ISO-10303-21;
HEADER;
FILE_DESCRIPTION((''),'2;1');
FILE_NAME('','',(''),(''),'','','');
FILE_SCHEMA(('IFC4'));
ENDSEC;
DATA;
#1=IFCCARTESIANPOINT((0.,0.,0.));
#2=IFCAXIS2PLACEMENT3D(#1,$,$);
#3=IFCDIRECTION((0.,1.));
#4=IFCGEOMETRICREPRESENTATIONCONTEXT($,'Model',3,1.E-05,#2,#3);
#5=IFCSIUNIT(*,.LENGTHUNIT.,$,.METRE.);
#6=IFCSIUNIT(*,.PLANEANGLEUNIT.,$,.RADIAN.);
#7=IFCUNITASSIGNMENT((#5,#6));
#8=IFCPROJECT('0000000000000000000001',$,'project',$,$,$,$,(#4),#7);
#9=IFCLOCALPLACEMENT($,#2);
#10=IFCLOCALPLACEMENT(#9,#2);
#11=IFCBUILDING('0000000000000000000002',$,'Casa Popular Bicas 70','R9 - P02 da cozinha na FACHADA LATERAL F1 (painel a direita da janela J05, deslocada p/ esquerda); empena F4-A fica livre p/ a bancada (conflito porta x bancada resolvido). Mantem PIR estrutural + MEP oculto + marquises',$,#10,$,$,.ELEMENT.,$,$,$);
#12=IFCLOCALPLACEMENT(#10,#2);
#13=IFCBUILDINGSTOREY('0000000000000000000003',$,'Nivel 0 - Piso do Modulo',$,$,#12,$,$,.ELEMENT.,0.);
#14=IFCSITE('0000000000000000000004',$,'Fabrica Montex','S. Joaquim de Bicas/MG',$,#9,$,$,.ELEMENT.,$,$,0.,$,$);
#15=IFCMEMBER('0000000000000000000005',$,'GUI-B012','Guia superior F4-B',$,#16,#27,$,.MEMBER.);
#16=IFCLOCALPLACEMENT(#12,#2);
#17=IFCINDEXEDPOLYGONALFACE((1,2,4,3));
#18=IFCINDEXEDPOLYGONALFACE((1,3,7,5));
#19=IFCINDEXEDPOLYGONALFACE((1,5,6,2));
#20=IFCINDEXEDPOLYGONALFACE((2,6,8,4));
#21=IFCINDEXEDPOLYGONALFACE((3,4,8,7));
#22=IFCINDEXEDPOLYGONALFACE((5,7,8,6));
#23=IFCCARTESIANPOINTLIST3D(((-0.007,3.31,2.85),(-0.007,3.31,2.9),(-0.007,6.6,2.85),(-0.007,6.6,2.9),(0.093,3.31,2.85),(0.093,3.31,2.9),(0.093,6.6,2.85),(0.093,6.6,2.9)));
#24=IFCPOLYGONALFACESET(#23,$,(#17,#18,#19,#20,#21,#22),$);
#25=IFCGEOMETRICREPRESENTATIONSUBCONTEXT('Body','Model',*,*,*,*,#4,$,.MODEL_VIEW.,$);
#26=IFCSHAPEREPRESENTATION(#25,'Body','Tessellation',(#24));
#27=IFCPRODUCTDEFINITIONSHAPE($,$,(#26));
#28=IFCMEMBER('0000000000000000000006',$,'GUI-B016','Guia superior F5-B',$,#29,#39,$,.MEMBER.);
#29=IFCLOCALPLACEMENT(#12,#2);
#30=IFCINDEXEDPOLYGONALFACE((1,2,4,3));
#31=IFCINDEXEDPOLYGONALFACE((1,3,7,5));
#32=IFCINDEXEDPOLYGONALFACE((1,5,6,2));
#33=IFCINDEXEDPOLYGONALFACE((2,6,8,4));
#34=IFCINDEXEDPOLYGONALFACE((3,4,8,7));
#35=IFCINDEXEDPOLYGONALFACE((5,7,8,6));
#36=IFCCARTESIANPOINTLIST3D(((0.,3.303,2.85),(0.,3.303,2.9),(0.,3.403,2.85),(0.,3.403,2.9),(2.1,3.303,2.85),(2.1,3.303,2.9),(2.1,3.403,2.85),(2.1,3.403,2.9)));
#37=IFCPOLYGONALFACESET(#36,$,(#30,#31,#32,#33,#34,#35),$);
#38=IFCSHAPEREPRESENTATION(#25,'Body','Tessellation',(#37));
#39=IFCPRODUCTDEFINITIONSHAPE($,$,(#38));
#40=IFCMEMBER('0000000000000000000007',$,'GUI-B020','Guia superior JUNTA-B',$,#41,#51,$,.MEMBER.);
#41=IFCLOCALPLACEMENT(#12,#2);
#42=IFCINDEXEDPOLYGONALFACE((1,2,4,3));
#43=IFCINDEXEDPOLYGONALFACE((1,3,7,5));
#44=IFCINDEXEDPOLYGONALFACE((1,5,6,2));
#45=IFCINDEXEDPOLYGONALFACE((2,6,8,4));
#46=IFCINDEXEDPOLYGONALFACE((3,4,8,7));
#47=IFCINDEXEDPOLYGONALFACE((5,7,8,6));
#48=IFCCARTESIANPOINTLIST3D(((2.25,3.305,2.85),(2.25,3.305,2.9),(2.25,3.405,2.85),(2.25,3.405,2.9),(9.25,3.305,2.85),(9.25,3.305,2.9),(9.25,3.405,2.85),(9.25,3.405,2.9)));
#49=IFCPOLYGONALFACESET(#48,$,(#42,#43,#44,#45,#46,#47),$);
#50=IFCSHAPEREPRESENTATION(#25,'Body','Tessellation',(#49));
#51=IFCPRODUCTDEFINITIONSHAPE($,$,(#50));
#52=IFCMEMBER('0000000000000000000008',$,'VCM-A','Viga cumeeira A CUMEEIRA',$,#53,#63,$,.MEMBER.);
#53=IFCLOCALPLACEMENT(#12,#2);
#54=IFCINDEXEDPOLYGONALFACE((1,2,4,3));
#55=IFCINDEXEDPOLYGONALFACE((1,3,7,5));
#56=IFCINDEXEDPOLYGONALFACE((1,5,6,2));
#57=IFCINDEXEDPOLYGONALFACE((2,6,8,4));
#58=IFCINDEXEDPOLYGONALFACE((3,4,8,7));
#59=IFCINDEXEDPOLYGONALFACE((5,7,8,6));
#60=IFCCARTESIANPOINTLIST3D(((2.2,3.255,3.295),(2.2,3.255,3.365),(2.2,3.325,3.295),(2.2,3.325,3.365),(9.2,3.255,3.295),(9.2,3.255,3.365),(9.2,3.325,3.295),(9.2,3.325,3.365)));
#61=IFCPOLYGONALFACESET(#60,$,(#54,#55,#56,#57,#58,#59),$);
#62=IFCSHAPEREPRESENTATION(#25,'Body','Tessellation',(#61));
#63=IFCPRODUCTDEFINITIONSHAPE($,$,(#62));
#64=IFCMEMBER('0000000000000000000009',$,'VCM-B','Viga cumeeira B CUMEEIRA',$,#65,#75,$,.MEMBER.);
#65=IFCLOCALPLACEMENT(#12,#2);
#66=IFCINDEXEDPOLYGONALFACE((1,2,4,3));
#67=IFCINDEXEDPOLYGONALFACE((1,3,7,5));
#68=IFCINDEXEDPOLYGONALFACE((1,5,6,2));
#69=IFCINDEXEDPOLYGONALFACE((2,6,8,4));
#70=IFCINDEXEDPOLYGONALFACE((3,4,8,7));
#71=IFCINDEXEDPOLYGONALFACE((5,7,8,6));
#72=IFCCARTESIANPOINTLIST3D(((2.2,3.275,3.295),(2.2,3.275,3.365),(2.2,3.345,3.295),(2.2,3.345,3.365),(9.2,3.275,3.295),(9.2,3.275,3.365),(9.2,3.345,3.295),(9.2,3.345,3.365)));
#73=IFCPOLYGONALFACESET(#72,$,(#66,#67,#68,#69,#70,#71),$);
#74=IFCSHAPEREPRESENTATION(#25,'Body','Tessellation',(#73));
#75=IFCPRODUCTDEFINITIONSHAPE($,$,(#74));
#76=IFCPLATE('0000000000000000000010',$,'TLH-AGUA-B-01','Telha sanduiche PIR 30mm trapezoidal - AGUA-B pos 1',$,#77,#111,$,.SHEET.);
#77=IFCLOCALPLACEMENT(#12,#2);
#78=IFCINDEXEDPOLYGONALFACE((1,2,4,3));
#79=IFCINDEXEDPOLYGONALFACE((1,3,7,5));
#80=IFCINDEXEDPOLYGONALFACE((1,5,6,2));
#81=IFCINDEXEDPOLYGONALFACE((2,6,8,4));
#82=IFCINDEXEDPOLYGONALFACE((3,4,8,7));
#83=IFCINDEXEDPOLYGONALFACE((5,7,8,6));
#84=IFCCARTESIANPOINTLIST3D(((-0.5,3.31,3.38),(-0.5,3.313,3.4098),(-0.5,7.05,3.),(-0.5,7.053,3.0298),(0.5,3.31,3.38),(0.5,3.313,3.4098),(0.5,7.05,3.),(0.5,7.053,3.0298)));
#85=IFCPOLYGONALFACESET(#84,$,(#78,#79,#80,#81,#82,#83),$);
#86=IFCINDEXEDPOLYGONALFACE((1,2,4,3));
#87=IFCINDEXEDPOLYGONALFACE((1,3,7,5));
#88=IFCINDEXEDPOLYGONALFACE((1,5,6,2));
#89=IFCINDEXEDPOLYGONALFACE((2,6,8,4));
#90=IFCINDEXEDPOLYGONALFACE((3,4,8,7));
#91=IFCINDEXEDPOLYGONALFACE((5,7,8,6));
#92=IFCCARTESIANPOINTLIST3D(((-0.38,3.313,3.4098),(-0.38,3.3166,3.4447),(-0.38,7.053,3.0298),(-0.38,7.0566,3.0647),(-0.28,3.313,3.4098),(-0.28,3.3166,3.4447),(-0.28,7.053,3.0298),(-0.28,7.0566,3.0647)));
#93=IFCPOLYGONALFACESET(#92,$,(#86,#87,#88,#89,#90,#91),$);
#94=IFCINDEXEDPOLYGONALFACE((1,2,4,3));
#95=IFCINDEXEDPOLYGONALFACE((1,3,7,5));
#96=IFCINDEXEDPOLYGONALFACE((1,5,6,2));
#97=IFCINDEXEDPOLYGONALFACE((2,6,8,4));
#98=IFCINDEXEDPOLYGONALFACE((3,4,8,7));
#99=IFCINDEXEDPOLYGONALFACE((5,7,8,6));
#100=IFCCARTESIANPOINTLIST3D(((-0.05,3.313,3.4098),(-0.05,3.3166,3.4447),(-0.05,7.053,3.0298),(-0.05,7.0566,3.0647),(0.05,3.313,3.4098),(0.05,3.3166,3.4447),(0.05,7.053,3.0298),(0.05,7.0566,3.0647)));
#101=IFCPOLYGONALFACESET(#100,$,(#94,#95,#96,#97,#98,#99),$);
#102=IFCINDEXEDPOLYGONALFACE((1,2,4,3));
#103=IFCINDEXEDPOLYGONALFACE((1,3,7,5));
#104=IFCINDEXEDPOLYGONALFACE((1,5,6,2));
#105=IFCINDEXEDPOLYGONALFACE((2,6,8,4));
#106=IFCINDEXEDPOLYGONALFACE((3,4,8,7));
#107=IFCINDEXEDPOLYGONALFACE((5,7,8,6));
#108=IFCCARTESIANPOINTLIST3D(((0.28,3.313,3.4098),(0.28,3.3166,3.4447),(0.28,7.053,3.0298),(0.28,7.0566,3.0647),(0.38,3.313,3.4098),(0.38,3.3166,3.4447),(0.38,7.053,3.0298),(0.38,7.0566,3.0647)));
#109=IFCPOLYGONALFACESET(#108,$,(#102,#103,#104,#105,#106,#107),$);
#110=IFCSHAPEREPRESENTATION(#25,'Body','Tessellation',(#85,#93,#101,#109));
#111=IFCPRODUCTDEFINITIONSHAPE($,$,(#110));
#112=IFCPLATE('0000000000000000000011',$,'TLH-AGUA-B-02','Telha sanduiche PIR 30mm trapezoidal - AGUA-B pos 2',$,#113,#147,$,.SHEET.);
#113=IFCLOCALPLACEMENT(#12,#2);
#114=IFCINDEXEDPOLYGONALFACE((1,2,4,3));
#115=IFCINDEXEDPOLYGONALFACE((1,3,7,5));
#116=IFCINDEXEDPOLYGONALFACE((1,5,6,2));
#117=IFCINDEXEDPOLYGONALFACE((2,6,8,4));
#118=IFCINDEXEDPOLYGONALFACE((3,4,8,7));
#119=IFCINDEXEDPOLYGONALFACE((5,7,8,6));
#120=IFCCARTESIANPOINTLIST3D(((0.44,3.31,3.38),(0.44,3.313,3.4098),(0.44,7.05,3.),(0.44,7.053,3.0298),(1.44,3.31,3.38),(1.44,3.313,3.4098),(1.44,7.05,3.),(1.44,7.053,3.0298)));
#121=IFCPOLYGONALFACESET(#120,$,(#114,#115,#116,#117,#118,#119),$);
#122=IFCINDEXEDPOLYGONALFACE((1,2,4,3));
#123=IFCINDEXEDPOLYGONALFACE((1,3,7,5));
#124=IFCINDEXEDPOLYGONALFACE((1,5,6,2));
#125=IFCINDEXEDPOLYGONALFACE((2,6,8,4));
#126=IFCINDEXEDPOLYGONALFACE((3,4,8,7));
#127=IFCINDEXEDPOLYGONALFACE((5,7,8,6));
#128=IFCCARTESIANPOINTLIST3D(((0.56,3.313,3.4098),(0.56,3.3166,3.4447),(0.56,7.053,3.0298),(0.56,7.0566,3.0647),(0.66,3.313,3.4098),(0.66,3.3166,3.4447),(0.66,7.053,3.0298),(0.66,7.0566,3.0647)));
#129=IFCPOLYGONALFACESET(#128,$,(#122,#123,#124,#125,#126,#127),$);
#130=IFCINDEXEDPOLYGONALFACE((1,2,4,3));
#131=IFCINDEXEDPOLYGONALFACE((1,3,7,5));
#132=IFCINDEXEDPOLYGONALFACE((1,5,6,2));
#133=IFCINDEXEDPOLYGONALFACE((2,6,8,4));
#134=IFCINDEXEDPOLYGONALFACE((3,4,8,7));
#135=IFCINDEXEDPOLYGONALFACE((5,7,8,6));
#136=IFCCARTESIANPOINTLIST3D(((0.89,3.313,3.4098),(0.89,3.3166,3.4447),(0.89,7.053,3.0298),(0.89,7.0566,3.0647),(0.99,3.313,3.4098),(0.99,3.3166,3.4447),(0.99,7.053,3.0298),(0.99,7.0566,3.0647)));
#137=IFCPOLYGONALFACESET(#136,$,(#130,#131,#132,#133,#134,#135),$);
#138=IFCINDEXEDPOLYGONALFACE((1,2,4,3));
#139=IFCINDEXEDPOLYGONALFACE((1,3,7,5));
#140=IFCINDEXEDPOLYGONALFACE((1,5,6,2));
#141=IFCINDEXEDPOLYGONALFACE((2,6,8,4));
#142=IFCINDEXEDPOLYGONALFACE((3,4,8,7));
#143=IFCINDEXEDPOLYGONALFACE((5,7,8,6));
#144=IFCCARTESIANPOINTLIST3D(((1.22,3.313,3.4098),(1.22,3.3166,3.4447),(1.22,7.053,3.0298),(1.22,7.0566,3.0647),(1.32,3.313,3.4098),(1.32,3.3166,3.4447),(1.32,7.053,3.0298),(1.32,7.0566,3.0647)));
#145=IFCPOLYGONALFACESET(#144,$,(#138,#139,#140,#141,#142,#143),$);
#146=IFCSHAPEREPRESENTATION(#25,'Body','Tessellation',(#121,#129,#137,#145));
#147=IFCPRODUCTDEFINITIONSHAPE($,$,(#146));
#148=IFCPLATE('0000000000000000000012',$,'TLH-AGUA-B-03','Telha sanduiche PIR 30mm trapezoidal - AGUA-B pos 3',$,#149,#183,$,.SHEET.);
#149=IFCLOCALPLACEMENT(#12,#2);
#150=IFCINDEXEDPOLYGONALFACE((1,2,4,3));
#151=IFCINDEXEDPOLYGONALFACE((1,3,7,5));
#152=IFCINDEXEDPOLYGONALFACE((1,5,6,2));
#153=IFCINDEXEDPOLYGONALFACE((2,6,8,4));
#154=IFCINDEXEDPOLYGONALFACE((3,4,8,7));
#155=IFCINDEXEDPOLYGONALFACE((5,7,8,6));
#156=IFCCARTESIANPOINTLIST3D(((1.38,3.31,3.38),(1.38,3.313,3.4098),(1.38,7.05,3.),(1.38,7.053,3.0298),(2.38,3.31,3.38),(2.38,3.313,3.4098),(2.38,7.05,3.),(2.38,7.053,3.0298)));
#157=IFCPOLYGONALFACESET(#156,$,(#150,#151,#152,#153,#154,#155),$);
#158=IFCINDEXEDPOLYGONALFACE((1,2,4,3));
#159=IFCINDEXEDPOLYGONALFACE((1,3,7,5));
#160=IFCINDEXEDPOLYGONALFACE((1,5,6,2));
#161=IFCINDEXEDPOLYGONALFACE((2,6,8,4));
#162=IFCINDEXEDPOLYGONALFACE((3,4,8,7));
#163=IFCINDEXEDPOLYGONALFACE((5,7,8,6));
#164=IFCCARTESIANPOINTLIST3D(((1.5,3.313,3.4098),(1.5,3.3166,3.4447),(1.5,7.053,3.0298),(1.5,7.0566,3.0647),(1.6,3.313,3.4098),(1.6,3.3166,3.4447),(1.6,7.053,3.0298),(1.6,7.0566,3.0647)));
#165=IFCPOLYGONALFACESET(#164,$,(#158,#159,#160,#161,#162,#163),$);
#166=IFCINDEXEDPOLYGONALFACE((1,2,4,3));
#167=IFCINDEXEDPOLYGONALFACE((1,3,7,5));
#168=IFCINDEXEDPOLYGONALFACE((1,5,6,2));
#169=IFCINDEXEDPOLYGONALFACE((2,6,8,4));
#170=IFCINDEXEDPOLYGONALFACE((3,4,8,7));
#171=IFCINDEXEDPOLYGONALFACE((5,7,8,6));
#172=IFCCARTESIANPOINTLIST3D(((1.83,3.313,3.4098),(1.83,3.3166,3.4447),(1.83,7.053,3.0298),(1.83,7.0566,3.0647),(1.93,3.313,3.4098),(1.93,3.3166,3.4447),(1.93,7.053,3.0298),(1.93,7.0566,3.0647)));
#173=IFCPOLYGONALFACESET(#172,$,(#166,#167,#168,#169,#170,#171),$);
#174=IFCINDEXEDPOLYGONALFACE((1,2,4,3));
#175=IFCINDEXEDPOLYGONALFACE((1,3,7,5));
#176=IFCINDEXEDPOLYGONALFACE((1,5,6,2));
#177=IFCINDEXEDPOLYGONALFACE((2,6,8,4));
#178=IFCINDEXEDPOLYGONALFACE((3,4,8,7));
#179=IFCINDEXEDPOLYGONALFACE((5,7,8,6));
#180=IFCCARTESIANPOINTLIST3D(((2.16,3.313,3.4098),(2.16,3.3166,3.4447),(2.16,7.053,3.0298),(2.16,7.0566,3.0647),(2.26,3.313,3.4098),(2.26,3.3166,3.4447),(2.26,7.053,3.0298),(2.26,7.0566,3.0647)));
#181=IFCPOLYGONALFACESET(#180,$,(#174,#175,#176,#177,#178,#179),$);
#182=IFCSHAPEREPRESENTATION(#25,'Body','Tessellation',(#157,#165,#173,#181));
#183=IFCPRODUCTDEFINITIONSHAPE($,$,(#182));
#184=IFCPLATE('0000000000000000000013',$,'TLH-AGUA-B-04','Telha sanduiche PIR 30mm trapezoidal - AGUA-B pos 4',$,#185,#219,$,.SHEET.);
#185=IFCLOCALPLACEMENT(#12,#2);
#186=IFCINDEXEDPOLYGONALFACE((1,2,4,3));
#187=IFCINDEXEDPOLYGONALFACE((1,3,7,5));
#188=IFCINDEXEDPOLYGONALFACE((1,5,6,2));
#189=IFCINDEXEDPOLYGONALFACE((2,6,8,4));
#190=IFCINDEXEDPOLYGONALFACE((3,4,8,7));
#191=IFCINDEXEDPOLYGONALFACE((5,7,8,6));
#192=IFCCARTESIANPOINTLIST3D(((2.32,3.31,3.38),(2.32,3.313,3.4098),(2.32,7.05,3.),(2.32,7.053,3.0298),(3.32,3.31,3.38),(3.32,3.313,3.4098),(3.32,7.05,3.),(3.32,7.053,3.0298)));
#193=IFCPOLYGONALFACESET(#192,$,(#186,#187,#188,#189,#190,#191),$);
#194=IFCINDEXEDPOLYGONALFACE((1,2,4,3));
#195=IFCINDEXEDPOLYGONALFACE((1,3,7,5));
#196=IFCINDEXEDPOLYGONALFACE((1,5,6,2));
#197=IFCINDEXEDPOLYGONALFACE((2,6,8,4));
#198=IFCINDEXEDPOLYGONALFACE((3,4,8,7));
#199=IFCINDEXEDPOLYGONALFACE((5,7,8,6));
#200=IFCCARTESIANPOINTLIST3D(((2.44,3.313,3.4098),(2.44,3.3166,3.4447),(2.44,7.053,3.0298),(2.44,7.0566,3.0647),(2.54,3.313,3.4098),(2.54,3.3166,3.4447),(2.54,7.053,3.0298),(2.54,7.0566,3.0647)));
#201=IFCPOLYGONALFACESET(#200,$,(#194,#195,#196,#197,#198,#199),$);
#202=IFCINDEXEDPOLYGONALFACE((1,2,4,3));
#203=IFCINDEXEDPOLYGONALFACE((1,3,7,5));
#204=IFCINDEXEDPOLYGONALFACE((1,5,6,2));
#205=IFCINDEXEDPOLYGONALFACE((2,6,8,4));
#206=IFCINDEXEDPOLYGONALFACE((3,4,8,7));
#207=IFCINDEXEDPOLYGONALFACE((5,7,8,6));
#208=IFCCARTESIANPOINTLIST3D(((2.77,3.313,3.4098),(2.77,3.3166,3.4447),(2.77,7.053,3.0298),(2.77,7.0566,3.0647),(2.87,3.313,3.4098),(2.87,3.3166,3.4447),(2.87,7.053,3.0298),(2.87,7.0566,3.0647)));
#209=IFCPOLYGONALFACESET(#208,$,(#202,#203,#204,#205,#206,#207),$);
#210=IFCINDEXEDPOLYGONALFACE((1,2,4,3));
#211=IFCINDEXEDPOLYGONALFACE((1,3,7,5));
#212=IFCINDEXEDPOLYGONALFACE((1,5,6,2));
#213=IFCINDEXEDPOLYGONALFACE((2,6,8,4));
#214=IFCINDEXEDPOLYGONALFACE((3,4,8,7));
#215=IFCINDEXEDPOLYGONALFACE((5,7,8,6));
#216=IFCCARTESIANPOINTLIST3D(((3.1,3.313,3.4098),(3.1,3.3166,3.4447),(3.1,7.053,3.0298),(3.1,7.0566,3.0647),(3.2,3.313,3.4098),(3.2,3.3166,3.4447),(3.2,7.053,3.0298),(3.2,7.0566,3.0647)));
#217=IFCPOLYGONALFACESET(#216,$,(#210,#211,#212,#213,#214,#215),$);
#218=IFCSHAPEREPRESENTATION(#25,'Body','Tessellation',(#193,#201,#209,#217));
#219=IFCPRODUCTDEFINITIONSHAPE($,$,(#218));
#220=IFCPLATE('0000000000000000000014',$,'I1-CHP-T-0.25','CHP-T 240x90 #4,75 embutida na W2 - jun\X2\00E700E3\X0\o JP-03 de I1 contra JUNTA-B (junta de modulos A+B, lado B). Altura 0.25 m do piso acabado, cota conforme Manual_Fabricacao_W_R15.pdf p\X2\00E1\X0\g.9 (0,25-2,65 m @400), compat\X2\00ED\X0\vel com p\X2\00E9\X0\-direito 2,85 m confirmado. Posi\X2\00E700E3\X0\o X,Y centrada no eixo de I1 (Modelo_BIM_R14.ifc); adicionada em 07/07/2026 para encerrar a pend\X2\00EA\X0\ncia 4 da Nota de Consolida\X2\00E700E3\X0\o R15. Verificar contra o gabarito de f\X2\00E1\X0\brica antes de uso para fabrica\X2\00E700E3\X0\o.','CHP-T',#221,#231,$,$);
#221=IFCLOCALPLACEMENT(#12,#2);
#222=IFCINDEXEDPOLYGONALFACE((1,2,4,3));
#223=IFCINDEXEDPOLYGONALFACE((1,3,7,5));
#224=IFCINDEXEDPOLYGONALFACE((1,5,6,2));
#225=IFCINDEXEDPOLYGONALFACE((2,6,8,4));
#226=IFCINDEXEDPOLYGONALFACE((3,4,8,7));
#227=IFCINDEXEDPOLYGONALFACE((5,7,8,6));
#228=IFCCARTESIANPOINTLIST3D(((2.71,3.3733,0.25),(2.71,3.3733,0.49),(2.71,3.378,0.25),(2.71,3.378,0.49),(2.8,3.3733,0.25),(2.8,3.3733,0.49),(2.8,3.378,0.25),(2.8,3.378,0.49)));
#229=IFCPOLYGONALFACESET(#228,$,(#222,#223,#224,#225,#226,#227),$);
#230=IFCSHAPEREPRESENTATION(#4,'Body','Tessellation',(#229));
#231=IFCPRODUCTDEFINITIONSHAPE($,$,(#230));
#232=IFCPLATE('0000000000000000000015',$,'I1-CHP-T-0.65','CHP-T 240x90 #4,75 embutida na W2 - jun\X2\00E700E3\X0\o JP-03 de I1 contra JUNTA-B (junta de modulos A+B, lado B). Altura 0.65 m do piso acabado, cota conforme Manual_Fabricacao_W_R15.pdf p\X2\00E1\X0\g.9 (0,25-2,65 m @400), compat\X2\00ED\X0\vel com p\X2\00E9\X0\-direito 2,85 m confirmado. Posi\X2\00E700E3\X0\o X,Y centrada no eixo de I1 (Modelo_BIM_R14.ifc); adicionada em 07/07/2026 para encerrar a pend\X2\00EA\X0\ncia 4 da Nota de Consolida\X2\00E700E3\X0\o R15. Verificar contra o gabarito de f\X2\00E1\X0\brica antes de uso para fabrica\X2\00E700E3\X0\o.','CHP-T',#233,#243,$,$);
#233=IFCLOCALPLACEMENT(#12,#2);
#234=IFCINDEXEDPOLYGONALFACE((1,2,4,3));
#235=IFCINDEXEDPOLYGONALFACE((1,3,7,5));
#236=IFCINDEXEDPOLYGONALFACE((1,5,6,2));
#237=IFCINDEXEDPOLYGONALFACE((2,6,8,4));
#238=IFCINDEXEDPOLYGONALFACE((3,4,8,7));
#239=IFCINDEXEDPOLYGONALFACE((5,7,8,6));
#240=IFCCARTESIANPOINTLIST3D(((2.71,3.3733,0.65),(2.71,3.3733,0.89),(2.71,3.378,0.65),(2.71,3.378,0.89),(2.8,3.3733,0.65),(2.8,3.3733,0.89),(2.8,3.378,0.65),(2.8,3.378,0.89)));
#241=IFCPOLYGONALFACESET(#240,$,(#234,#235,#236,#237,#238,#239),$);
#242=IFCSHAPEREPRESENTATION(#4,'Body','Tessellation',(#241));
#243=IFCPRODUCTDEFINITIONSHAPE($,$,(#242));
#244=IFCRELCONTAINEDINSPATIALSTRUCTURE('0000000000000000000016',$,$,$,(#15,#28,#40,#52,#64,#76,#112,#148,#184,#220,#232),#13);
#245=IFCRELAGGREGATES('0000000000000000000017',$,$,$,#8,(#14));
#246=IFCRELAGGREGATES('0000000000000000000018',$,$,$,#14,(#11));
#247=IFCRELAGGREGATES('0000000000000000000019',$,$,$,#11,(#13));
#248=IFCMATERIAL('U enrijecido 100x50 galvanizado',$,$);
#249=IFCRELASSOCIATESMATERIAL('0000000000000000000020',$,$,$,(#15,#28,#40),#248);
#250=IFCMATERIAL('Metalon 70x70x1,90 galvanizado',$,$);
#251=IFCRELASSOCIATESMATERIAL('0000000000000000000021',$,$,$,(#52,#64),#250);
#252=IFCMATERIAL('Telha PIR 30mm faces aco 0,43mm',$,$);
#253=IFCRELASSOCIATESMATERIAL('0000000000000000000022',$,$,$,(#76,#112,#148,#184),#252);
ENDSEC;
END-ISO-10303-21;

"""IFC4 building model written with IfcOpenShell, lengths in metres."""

from ifc_helpers import new_model, si_unit, direction, frame, frame_2d, origin, origin_with_axes, origin_2d, place, context, subcontext, project, spatial, rectangle, extrude, material, element, save


model = new_model("IFC4")

# Units and contexts
model_context = context("Model", 3, precision=1e-05, world=origin(), true_north=direction((0.0, 1.0)))
body_context = subcontext(model_context, "Body", "Model", "MODEL_VIEW")
ifc_project = project(units=[si_unit("LENGTHUNIT", "METRE"), si_unit("PLANEANGLEUNIT", "RADIAN")], contexts=[model_context])

# Site, building, storey
site_placement = place(None, origin())
site = spatial("IfcSite", under=ifc_project, at=site_placement, Name="Fabrica Montex", Description="S. Joaquim de Bicas/MG", CompositionType="ELEMENT", RefElevation=0.0)
building_placement = place(site_placement, origin())
building = spatial("IfcBuilding", under=site, at=building_placement, Name="Casa Popular Bicas 70", Description="R9 - P02 da cozinha na FACHADA LATERAL F1 (painel a direita da janela J05, deslocada p/ esquerda); empena F4-A fica livre p/ a bancada (conflito porta x bancada resolvido). Mantem PIR estrutural + MEP oculto + marquises", CompositionType="ELEMENT")
storey_placement = place(building_placement, origin())
storey = spatial("IfcBuildingStorey", under=building, at=storey_placement, Name="Nivel 0 - Piso do Modulo", CompositionType="ELEMENT", Elevation=0.0)

# Members
ifc_material_1 = material(Name="U enrijecido 100x50 galvanizado")
member_1_placement = place(storey_placement, frame((0.043, 3.31, 2.875), z_axis=(0.0, 1.0, 0.0), x_axis=(0.0, 0.0, 1.0)))
element("IfcMember", 1, at=member_1_placement, inside=storey, material=ifc_material_1, Name="GUI-B012", Description="Guia superior F4-B", PredefinedType="MEMBER", context=body_context, shape_type="SweptSolid", body=[
    extrude(rectangle(XDim=0.05, YDim=0.1, at=origin_2d()), origin(), (0.0, 0.0, 1.0), 3.29),
])
member_2_placement = place(storey_placement, frame((0.0, 3.353, 2.875), z_axis=(1.0, 0.0, 0.0), x_axis=(0.0, 0.0, 1.0)))
element("IfcMember", 2, at=member_2_placement, inside=storey, material=ifc_material_1, Name="GUI-B016", Description="Guia superior F5-B", PredefinedType="MEMBER", context=body_context, shape_type="SweptSolid", body=[
    extrude(rectangle(XDim=0.05, YDim=0.1, at=origin_2d()), origin(), (0.0, 0.0, 1.0), 2.1),
])
member_3_placement = place(storey_placement, frame((2.25, 3.355, 2.875), z_axis=(1.0, 0.0, 0.0), x_axis=(0.0, 0.0, 1.0)))
element("IfcMember", 3, at=member_3_placement, inside=storey, material=ifc_material_1, Name="GUI-B020", Description="Guia superior JUNTA-B", PredefinedType="MEMBER", context=body_context, shape_type="SweptSolid", body=[
    extrude(rectangle(XDim=0.05, YDim=0.1, at=origin_2d()), origin(), (0.0, 0.0, 1.0), 7.0),
])
ifc_material_2 = material(Name="Metalon 70x70x1,90 galvanizado")
for number, where, z_axis, x_axis, name, description in (
    (4, (2.2, 3.29, 3.33), (1.0, 0.0, 0.0), (0.0, 0.0, 1.0), "VCM-A", "Viga cumeeira A CUMEEIRA"),
    (5, (2.2, 3.31, 3.33), (1.0, 0.0, 0.0), (0.0, 0.0, 1.0), "VCM-B", "Viga cumeeira B CUMEEIRA"),
):
    element("IfcMember", number, at=place(storey_placement, frame(where, z_axis=z_axis, x_axis=x_axis)), inside=storey, material=ifc_material_2, Name=name, Description=description, PredefinedType="MEMBER", context=body_context, shape_type="SweptSolid", body=[
        extrude(rectangle(XDim=0.07, YDim=0.07, at=origin_2d()), origin(), (0.0, 0.0, 1.0), 7.0),
    ])

# Plates
ifc_material_3 = material(Name="Telha PIR 30mm faces aco 0,43mm")
for number, where, z_axis, x_axis, name, description in (
    (6, (-0.5, 3.31, 3.38), (0.0, 0.101084, 0.994878), (1.0, 0.0, 0.0), "TLH-AGUA-B-01", "Telha sanduiche PIR 30mm trapezoidal - AGUA-B pos 1"),
    (7, (0.44, 3.31, 3.38), (0.0, 0.101084, 0.994878), (1.0, 0.0, 0.0), "TLH-AGUA-B-02", "Telha sanduiche PIR 30mm trapezoidal - AGUA-B pos 2"),
    (8, (1.38, 3.31, 3.38), (0.0, 0.101084, 0.994878), (1.0, 0.0, 0.0), "TLH-AGUA-B-03", "Telha sanduiche PIR 30mm trapezoidal - AGUA-B pos 3"),
    (9, (2.32, 3.31, 3.38), (0.0, 0.101084, 0.994878), (1.0, 0.0, 0.0), "TLH-AGUA-B-04", "Telha sanduiche PIR 30mm trapezoidal - AGUA-B pos 4"),
):
    element("IfcPlate", number, at=place(storey_placement, frame(where, z_axis=z_axis, x_axis=x_axis)), inside=storey, material=ifc_material_3, Name=name, Description=description, PredefinedType="SHEET", context=body_context, shape_type="SweptSolid", body=[
        extrude(rectangle(XDim=1.0, YDim=3.7593, at=frame_2d((0.5, 1.8796))), origin(), (0.0, 0.0, 1.0), 0.03),
        extrude(rectangle(XDim=0.1, YDim=3.7593, at=frame_2d((0.17, 1.8796))), frame((0.0, 0.0, 0.03)), (0.0, 0.0, 1.0), 0.035),
        extrude(rectangle(XDim=0.1, YDim=3.7593, at=frame_2d((0.5, 1.8796))), frame((0.0, 0.0, 0.03)), (0.0, 0.0, 1.0), 0.035),
        extrude(rectangle(XDim=0.1, YDim=3.7593, at=frame_2d((0.83, 1.8796))), frame((0.0, 0.0, 0.03)), (0.0, 0.0, 1.0), 0.035),
    ])
for number, where, z_axis, x_axis, name, description in (
    (10, (2.755, 3.3756, 0.25), (0.0, 0.0, 1.0), (1.0, 0.0, 0.0), "I1-CHP-T-0.25", "CHP-T 240x90 #4,75 embutida na W2 - junção JP-03 de I1 contra JUNTA-B (junta de modulos A+B, lado B). Altura 0.25 m do piso acabado, cota conforme Manual_Fabricacao_W_R15.pdf pág.9 (0,25-2,65 m @400), compatível com pé-direito 2,85 m confirmado. Posição X,Y centrada no eixo de I1 (Modelo_BIM_R14.ifc); adicionada em 07/07/2026 para encerrar a pendência 4 da Nota de Consolidação R15. Verificar contra o gabarito de fábrica antes de uso para fabricação."),
    (11, (2.755, 3.3756, 0.65), (0.0, 0.0, 1.0), (1.0, 0.0, 0.0), "I1-CHP-T-0.65", "CHP-T 240x90 #4,75 embutida na W2 - junção JP-03 de I1 contra JUNTA-B (junta de modulos A+B, lado B). Altura 0.65 m do piso acabado, cota conforme Manual_Fabricacao_W_R15.pdf pág.9 (0,25-2,65 m @400), compatível com pé-direito 2,85 m confirmado. Posição X,Y centrada no eixo de I1 (Modelo_BIM_R14.ifc); adicionada em 07/07/2026 para encerrar a pendência 4 da Nota de Consolidação R15. Verificar contra o gabarito de fábrica antes de uso para fabricação."),
):
    element("IfcPlate", number, at=place(storey_placement, frame(where, z_axis=z_axis, x_axis=x_axis)), inside=storey, Name=name, Description=description, ObjectType="CHP-T", context=model_context, shape_type="SweptSolid", body=[
        extrude(rectangle(XDim=0.09, YDim=0.0047, at=origin_2d()), origin_with_axes(), (0.0, 0.0, 1.0), 0.24),
    ])

save(model, "model.ifc")
